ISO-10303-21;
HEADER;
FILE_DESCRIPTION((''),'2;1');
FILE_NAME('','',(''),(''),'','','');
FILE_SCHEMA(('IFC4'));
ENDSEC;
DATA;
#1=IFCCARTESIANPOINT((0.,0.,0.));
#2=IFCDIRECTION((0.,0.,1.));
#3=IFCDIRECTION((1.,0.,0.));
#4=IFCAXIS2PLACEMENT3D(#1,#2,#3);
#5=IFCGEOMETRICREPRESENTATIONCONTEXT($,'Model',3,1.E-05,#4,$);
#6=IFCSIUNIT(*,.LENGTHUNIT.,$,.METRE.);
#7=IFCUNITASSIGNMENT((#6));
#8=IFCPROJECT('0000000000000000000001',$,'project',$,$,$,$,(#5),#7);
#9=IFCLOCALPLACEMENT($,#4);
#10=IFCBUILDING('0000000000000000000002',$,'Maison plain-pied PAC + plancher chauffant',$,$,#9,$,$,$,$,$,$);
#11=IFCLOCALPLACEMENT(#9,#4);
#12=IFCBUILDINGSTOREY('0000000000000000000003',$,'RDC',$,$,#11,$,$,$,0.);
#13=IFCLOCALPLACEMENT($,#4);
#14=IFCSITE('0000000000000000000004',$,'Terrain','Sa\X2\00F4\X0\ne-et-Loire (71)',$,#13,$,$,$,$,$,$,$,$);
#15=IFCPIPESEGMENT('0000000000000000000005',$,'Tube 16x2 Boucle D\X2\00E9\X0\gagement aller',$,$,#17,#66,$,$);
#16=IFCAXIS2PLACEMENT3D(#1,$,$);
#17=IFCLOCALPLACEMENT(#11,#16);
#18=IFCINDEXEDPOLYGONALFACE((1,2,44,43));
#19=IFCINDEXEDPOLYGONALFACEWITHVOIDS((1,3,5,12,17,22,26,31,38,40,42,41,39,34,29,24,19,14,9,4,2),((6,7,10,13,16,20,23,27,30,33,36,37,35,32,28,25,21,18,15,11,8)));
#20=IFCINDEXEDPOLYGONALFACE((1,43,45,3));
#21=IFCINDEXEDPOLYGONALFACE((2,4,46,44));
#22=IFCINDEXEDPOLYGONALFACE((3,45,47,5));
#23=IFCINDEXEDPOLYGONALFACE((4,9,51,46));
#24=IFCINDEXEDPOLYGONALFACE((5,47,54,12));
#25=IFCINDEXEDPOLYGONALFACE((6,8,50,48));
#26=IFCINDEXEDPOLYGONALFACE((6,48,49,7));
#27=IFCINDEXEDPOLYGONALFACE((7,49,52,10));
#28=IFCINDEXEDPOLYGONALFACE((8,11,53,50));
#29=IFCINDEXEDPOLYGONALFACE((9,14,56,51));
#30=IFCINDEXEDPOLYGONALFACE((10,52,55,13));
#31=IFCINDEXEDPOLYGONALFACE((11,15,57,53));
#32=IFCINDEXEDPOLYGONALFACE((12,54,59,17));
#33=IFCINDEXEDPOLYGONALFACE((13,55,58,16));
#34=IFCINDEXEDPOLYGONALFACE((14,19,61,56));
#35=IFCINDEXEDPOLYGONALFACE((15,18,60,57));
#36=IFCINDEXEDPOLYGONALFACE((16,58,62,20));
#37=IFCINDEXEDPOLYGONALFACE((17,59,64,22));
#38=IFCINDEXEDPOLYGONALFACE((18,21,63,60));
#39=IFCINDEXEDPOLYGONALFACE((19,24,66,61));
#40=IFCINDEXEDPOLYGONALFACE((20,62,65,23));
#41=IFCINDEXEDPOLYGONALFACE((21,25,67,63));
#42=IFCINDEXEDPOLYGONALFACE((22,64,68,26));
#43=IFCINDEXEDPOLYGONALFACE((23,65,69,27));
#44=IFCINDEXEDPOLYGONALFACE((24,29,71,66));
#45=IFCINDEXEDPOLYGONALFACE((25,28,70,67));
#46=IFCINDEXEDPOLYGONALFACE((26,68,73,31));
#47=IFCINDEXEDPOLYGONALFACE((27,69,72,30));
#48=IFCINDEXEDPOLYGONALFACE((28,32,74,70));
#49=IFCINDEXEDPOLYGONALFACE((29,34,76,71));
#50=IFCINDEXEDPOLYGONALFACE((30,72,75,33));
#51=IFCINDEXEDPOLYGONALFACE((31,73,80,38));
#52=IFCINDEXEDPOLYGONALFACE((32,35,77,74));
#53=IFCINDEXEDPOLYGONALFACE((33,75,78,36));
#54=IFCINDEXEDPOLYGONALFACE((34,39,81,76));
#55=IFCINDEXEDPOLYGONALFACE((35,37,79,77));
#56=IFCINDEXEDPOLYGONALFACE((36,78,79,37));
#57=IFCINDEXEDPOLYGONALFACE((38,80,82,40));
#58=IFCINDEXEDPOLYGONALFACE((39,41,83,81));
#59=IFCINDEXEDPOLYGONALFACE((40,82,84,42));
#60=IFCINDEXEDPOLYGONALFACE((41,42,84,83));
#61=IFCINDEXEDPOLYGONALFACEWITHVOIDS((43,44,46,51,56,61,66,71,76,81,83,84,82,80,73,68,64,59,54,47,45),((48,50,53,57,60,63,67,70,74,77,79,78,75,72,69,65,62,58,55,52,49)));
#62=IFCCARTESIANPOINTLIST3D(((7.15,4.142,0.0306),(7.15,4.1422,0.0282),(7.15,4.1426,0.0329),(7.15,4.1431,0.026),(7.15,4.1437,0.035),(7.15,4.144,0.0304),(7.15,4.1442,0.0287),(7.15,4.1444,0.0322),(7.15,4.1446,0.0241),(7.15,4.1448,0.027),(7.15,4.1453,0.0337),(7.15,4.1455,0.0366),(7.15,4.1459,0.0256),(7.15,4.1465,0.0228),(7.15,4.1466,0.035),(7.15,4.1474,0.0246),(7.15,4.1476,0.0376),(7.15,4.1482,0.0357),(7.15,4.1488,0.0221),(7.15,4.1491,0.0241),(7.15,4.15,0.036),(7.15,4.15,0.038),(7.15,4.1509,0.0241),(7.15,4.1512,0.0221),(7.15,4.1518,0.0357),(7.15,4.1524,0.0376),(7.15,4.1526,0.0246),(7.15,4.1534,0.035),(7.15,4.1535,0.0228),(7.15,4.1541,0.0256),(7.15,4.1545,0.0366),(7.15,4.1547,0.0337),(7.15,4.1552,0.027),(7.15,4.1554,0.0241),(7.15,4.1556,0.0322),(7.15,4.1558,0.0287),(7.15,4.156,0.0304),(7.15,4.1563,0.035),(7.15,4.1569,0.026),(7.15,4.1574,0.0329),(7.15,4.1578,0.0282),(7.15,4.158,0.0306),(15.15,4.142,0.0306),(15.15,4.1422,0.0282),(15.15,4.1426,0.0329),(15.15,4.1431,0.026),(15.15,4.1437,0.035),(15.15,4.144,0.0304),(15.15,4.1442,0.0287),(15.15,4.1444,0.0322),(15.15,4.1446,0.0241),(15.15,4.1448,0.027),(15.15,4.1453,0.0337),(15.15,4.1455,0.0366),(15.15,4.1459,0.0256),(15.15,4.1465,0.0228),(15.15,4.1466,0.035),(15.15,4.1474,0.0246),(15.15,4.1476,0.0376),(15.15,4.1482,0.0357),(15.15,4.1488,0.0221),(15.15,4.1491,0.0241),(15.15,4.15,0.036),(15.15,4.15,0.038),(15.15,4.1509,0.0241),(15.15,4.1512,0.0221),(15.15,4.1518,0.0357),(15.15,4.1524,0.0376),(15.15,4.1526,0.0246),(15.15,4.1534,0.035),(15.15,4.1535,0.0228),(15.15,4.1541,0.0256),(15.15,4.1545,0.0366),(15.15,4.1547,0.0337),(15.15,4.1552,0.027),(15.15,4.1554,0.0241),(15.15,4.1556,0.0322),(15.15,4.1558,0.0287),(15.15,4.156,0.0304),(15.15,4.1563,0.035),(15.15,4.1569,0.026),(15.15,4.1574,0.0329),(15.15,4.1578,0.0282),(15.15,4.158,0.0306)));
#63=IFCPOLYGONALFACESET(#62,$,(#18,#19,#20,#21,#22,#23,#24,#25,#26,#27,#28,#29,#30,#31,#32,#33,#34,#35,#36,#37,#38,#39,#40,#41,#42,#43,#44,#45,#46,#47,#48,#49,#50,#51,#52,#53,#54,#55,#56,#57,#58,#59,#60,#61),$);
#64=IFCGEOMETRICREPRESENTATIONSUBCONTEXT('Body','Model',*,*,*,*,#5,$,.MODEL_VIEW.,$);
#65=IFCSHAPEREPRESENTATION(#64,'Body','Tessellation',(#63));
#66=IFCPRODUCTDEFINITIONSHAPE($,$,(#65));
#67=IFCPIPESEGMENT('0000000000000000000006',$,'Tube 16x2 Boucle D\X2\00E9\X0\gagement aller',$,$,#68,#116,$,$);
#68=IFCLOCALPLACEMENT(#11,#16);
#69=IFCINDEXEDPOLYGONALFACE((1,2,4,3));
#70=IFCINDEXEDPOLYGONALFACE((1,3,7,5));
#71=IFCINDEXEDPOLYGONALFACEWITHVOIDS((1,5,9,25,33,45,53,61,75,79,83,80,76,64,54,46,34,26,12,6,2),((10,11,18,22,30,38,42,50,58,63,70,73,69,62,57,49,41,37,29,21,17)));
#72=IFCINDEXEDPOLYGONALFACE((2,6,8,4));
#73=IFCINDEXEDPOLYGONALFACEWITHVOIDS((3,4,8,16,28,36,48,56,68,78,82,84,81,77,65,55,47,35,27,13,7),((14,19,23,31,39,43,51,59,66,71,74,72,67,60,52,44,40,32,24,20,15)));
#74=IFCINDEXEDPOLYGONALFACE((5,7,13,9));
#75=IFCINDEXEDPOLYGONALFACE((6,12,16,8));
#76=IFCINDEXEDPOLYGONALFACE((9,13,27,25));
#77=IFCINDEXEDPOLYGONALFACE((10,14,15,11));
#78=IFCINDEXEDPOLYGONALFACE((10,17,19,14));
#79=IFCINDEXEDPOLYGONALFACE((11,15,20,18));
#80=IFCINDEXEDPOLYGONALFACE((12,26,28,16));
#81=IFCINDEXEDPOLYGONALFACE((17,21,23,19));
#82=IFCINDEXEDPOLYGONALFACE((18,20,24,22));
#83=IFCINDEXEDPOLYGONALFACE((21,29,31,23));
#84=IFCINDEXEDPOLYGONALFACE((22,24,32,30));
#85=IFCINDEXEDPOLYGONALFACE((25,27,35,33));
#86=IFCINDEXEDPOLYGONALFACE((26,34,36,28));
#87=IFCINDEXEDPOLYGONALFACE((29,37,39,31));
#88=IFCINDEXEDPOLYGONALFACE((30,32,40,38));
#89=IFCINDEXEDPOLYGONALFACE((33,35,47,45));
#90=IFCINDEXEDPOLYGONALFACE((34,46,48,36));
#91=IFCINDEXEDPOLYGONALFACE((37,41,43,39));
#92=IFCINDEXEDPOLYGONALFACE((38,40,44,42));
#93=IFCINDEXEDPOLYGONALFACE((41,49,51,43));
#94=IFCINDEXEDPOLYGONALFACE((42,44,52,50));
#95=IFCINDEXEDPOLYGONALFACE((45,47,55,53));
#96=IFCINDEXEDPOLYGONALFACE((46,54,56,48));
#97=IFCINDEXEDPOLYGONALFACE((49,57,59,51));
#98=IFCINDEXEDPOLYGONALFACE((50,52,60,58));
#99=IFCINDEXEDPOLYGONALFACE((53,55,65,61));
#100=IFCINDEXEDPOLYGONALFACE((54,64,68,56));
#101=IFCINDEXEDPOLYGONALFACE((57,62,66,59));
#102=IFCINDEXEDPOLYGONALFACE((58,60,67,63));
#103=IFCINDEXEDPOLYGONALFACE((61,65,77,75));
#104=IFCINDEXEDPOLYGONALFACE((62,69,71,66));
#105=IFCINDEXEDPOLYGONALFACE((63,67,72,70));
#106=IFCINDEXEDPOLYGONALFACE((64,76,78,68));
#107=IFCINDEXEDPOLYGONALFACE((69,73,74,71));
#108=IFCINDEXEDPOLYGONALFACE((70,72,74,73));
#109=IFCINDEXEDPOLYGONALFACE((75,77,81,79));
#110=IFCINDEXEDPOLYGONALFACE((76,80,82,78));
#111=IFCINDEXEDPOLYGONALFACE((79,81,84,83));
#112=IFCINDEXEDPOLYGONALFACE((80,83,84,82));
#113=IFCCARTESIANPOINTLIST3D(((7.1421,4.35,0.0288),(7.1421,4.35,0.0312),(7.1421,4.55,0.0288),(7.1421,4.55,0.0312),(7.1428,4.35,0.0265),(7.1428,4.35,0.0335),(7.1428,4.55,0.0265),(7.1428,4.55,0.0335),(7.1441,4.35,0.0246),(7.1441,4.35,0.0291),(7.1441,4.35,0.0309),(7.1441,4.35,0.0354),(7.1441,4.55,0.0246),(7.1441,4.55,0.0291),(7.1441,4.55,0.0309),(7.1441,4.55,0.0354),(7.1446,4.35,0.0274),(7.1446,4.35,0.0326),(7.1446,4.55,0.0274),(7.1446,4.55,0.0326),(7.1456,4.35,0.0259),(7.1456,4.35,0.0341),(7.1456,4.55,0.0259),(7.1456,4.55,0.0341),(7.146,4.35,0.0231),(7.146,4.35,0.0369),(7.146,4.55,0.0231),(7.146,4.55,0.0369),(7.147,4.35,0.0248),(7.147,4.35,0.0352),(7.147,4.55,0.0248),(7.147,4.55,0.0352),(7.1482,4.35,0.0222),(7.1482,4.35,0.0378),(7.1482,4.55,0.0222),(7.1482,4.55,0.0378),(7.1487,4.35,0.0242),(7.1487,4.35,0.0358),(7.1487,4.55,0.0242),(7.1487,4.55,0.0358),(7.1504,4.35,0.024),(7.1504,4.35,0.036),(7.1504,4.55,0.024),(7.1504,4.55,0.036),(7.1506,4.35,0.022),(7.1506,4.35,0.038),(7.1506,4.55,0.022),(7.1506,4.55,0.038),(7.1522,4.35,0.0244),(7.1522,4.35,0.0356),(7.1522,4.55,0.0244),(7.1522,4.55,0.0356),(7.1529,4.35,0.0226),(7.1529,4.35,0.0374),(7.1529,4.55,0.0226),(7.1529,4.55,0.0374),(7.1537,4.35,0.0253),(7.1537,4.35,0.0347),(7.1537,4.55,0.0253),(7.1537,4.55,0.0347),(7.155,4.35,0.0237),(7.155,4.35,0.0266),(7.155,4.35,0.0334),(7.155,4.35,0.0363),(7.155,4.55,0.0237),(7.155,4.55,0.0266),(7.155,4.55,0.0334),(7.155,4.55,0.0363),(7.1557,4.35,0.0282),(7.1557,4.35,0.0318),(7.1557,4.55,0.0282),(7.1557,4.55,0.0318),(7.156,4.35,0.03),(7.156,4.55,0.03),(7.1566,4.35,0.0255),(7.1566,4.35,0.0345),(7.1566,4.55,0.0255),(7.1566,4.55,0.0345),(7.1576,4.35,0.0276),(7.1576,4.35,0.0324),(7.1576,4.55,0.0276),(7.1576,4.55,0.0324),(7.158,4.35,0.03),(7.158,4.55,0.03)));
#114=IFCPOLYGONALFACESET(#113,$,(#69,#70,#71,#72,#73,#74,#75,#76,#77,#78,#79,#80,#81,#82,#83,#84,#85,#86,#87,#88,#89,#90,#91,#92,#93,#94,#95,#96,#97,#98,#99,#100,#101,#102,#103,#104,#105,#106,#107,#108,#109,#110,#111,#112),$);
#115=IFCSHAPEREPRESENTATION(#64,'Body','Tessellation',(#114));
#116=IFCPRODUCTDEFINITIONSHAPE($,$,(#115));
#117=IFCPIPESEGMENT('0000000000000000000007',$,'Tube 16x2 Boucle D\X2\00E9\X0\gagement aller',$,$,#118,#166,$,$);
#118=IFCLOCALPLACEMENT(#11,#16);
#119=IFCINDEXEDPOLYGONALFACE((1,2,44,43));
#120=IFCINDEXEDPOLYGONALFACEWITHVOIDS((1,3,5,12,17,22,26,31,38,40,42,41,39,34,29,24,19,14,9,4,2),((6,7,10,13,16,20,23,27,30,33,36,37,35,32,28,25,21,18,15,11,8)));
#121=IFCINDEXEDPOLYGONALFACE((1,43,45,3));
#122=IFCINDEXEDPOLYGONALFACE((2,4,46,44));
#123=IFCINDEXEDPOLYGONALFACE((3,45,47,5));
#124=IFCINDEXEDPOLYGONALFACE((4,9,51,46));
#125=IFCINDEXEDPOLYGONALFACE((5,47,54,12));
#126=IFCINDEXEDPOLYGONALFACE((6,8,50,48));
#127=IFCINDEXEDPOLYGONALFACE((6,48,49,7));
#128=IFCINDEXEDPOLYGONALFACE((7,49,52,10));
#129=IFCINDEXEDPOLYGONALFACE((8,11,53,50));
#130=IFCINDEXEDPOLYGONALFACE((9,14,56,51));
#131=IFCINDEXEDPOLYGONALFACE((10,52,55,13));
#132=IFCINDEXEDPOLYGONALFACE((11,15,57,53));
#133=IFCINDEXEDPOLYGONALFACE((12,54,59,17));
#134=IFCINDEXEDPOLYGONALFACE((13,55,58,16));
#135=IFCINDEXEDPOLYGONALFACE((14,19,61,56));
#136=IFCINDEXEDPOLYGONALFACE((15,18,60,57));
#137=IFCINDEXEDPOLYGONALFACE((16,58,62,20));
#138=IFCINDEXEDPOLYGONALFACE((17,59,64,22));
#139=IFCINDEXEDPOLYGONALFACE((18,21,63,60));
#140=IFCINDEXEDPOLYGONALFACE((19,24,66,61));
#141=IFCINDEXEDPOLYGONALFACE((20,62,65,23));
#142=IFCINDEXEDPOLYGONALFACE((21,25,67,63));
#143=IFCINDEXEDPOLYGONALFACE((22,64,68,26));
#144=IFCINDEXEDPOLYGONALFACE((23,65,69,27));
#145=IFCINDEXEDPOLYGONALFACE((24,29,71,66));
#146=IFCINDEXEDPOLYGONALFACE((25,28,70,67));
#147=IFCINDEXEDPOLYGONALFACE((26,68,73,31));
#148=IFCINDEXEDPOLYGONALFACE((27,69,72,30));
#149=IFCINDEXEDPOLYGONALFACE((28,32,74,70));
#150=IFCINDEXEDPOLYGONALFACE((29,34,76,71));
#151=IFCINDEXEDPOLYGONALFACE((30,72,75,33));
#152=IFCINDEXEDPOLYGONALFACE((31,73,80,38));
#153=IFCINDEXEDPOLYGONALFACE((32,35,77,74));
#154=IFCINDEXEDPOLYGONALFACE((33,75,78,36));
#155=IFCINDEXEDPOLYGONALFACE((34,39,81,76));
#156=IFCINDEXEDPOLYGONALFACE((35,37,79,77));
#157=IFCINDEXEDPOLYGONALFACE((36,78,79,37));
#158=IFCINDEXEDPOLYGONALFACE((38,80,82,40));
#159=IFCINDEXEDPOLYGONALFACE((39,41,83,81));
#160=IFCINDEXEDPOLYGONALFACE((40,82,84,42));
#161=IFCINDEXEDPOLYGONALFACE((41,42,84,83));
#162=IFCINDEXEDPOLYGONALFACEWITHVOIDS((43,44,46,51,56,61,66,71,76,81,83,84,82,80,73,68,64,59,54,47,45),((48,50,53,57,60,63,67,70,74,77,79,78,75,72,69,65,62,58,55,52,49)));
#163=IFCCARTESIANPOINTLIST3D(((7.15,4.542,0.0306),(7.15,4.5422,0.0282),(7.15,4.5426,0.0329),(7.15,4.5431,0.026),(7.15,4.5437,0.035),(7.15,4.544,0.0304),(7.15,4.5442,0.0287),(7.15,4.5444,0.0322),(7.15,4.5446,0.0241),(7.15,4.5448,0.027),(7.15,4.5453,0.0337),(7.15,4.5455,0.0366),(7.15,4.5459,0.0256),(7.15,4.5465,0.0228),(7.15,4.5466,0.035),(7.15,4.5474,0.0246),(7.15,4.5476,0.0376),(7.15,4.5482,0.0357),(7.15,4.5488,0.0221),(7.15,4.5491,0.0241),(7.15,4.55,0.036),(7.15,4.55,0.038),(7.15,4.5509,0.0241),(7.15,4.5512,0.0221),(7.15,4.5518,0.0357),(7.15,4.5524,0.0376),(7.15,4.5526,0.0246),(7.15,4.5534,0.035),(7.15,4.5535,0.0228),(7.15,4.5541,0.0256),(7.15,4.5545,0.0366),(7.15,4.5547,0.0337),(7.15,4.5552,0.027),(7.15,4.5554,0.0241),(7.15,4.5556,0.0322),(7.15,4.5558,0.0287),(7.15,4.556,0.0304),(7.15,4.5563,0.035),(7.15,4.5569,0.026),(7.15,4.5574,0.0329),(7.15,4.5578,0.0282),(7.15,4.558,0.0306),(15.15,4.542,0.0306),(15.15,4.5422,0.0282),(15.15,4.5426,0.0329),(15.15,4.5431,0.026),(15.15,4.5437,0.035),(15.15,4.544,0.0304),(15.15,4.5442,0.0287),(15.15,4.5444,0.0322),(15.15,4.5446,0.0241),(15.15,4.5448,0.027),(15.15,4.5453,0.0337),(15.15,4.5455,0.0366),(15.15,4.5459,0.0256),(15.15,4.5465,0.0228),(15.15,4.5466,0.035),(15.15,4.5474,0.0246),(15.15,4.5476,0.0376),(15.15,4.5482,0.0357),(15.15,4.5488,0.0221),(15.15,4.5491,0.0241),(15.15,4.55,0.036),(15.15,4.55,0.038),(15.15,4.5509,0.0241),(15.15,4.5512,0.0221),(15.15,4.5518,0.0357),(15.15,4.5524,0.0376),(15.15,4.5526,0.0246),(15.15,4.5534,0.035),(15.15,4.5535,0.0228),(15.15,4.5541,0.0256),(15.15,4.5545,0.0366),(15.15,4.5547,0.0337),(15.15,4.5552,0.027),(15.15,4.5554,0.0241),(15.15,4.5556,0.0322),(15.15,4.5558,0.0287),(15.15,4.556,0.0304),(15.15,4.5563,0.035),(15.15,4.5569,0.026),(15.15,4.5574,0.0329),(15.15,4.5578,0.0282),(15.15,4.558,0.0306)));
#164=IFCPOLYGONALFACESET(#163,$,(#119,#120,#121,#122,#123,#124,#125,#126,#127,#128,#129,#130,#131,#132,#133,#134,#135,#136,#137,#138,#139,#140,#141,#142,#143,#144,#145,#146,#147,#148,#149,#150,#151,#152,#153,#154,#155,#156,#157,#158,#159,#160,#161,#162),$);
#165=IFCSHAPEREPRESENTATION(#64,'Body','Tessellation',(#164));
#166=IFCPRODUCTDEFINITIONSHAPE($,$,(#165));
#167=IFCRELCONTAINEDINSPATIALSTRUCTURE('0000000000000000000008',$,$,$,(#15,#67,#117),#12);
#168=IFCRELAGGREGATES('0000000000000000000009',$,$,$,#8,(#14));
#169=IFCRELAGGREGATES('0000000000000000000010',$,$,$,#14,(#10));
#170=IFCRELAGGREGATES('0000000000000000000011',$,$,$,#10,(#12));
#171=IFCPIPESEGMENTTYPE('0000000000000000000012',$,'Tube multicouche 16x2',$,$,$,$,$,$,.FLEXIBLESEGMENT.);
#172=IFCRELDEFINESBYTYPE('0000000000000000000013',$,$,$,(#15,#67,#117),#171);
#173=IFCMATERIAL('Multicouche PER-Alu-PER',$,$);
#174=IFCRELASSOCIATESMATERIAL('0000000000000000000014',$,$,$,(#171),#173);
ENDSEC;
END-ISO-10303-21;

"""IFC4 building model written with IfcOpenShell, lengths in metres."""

from ifc_helpers import new_model, si_unit, frame, origin_with_axes, place, context, subcontext, project, spatial, hollow_circle, extrude, material, type_object, element, save


model = new_model("IFC4")

# Units and contexts
model_context = context("Model", 3, precision=1e-05, world=origin_with_axes())
body_context = subcontext(model_context, "Body", "Model", "MODEL_VIEW")
ifc_project = project(units=[si_unit("LENGTHUNIT", "METRE")], contexts=[model_context])

# Site, building, storey
site_placement = place(None, origin_with_axes())
site = spatial("IfcSite", under=ifc_project, at=site_placement, Name="Terrain", Description="Saône-et-Loire (71)")
building_placement = place(None, origin_with_axes())
building = spatial("IfcBuilding", under=site, at=building_placement, Name="Maison plain-pied PAC + plancher chauffant")
storey_placement = place(building_placement, origin_with_axes())
storey = spatial("IfcBuildingStorey", under=building, at=storey_placement, Name="RDC", Elevation=0.0)

# Pipe segments
ifc_material = material(Name="Multicouche PER-Alu-PER")
pipe_segment_type = type_object("IfcPipeSegmentType", Name="Tube multicouche 16x2", PredefinedType="FLEXIBLESEGMENT", material=ifc_material)
pipe_segment_1_placement = place(storey_placement, frame((7.15, 4.15, 0.03), z_axis=(1.0, 0.0, 0.0), x_axis=(0.0, 0.0, 1.0)))
element("IfcPipeSegment", 1, at=pipe_segment_1_placement, inside=storey, type_object=pipe_segment_type, Name="Tube 16x2 Boucle Dégagement aller", context=body_context, shape_type="SweptSolid", body=[
    extrude(hollow_circle(Radius=0.008, WallThickness=0.002), origin_with_axes(), (0.0, 0.0, 1.0), 8.0),
])
pipe_segment_2_placement = place(storey_placement, frame((7.15, 4.35, 0.03), z_axis=(0.0, 1.0, 0.0), x_axis=(1.0, 0.0, 0.0)))
element("IfcPipeSegment", 2, at=pipe_segment_2_placement, inside=storey, type_object=pipe_segment_type, Name="Tube 16x2 Boucle Dégagement aller", context=body_context, shape_type="SweptSolid", body=[
    extrude(hollow_circle(Radius=0.008, WallThickness=0.002), origin_with_axes(), (0.0, 0.0, 1.0), 0.2),
])
pipe_segment_3_placement = place(storey_placement, frame((7.15, 4.55, 0.03), z_axis=(1.0, 0.0, 0.0), x_axis=(0.0, 0.0, 1.0)))
element("IfcPipeSegment", 3, at=pipe_segment_3_placement, inside=storey, type_object=pipe_segment_type, Name="Tube 16x2 Boucle Dégagement aller", context=body_context, shape_type="SweptSolid", body=[
    extrude(hollow_circle(Radius=0.008, WallThickness=0.002), origin_with_axes(), (0.0, 0.0, 1.0), 8.0),
])

save(model, "model.ifc")
